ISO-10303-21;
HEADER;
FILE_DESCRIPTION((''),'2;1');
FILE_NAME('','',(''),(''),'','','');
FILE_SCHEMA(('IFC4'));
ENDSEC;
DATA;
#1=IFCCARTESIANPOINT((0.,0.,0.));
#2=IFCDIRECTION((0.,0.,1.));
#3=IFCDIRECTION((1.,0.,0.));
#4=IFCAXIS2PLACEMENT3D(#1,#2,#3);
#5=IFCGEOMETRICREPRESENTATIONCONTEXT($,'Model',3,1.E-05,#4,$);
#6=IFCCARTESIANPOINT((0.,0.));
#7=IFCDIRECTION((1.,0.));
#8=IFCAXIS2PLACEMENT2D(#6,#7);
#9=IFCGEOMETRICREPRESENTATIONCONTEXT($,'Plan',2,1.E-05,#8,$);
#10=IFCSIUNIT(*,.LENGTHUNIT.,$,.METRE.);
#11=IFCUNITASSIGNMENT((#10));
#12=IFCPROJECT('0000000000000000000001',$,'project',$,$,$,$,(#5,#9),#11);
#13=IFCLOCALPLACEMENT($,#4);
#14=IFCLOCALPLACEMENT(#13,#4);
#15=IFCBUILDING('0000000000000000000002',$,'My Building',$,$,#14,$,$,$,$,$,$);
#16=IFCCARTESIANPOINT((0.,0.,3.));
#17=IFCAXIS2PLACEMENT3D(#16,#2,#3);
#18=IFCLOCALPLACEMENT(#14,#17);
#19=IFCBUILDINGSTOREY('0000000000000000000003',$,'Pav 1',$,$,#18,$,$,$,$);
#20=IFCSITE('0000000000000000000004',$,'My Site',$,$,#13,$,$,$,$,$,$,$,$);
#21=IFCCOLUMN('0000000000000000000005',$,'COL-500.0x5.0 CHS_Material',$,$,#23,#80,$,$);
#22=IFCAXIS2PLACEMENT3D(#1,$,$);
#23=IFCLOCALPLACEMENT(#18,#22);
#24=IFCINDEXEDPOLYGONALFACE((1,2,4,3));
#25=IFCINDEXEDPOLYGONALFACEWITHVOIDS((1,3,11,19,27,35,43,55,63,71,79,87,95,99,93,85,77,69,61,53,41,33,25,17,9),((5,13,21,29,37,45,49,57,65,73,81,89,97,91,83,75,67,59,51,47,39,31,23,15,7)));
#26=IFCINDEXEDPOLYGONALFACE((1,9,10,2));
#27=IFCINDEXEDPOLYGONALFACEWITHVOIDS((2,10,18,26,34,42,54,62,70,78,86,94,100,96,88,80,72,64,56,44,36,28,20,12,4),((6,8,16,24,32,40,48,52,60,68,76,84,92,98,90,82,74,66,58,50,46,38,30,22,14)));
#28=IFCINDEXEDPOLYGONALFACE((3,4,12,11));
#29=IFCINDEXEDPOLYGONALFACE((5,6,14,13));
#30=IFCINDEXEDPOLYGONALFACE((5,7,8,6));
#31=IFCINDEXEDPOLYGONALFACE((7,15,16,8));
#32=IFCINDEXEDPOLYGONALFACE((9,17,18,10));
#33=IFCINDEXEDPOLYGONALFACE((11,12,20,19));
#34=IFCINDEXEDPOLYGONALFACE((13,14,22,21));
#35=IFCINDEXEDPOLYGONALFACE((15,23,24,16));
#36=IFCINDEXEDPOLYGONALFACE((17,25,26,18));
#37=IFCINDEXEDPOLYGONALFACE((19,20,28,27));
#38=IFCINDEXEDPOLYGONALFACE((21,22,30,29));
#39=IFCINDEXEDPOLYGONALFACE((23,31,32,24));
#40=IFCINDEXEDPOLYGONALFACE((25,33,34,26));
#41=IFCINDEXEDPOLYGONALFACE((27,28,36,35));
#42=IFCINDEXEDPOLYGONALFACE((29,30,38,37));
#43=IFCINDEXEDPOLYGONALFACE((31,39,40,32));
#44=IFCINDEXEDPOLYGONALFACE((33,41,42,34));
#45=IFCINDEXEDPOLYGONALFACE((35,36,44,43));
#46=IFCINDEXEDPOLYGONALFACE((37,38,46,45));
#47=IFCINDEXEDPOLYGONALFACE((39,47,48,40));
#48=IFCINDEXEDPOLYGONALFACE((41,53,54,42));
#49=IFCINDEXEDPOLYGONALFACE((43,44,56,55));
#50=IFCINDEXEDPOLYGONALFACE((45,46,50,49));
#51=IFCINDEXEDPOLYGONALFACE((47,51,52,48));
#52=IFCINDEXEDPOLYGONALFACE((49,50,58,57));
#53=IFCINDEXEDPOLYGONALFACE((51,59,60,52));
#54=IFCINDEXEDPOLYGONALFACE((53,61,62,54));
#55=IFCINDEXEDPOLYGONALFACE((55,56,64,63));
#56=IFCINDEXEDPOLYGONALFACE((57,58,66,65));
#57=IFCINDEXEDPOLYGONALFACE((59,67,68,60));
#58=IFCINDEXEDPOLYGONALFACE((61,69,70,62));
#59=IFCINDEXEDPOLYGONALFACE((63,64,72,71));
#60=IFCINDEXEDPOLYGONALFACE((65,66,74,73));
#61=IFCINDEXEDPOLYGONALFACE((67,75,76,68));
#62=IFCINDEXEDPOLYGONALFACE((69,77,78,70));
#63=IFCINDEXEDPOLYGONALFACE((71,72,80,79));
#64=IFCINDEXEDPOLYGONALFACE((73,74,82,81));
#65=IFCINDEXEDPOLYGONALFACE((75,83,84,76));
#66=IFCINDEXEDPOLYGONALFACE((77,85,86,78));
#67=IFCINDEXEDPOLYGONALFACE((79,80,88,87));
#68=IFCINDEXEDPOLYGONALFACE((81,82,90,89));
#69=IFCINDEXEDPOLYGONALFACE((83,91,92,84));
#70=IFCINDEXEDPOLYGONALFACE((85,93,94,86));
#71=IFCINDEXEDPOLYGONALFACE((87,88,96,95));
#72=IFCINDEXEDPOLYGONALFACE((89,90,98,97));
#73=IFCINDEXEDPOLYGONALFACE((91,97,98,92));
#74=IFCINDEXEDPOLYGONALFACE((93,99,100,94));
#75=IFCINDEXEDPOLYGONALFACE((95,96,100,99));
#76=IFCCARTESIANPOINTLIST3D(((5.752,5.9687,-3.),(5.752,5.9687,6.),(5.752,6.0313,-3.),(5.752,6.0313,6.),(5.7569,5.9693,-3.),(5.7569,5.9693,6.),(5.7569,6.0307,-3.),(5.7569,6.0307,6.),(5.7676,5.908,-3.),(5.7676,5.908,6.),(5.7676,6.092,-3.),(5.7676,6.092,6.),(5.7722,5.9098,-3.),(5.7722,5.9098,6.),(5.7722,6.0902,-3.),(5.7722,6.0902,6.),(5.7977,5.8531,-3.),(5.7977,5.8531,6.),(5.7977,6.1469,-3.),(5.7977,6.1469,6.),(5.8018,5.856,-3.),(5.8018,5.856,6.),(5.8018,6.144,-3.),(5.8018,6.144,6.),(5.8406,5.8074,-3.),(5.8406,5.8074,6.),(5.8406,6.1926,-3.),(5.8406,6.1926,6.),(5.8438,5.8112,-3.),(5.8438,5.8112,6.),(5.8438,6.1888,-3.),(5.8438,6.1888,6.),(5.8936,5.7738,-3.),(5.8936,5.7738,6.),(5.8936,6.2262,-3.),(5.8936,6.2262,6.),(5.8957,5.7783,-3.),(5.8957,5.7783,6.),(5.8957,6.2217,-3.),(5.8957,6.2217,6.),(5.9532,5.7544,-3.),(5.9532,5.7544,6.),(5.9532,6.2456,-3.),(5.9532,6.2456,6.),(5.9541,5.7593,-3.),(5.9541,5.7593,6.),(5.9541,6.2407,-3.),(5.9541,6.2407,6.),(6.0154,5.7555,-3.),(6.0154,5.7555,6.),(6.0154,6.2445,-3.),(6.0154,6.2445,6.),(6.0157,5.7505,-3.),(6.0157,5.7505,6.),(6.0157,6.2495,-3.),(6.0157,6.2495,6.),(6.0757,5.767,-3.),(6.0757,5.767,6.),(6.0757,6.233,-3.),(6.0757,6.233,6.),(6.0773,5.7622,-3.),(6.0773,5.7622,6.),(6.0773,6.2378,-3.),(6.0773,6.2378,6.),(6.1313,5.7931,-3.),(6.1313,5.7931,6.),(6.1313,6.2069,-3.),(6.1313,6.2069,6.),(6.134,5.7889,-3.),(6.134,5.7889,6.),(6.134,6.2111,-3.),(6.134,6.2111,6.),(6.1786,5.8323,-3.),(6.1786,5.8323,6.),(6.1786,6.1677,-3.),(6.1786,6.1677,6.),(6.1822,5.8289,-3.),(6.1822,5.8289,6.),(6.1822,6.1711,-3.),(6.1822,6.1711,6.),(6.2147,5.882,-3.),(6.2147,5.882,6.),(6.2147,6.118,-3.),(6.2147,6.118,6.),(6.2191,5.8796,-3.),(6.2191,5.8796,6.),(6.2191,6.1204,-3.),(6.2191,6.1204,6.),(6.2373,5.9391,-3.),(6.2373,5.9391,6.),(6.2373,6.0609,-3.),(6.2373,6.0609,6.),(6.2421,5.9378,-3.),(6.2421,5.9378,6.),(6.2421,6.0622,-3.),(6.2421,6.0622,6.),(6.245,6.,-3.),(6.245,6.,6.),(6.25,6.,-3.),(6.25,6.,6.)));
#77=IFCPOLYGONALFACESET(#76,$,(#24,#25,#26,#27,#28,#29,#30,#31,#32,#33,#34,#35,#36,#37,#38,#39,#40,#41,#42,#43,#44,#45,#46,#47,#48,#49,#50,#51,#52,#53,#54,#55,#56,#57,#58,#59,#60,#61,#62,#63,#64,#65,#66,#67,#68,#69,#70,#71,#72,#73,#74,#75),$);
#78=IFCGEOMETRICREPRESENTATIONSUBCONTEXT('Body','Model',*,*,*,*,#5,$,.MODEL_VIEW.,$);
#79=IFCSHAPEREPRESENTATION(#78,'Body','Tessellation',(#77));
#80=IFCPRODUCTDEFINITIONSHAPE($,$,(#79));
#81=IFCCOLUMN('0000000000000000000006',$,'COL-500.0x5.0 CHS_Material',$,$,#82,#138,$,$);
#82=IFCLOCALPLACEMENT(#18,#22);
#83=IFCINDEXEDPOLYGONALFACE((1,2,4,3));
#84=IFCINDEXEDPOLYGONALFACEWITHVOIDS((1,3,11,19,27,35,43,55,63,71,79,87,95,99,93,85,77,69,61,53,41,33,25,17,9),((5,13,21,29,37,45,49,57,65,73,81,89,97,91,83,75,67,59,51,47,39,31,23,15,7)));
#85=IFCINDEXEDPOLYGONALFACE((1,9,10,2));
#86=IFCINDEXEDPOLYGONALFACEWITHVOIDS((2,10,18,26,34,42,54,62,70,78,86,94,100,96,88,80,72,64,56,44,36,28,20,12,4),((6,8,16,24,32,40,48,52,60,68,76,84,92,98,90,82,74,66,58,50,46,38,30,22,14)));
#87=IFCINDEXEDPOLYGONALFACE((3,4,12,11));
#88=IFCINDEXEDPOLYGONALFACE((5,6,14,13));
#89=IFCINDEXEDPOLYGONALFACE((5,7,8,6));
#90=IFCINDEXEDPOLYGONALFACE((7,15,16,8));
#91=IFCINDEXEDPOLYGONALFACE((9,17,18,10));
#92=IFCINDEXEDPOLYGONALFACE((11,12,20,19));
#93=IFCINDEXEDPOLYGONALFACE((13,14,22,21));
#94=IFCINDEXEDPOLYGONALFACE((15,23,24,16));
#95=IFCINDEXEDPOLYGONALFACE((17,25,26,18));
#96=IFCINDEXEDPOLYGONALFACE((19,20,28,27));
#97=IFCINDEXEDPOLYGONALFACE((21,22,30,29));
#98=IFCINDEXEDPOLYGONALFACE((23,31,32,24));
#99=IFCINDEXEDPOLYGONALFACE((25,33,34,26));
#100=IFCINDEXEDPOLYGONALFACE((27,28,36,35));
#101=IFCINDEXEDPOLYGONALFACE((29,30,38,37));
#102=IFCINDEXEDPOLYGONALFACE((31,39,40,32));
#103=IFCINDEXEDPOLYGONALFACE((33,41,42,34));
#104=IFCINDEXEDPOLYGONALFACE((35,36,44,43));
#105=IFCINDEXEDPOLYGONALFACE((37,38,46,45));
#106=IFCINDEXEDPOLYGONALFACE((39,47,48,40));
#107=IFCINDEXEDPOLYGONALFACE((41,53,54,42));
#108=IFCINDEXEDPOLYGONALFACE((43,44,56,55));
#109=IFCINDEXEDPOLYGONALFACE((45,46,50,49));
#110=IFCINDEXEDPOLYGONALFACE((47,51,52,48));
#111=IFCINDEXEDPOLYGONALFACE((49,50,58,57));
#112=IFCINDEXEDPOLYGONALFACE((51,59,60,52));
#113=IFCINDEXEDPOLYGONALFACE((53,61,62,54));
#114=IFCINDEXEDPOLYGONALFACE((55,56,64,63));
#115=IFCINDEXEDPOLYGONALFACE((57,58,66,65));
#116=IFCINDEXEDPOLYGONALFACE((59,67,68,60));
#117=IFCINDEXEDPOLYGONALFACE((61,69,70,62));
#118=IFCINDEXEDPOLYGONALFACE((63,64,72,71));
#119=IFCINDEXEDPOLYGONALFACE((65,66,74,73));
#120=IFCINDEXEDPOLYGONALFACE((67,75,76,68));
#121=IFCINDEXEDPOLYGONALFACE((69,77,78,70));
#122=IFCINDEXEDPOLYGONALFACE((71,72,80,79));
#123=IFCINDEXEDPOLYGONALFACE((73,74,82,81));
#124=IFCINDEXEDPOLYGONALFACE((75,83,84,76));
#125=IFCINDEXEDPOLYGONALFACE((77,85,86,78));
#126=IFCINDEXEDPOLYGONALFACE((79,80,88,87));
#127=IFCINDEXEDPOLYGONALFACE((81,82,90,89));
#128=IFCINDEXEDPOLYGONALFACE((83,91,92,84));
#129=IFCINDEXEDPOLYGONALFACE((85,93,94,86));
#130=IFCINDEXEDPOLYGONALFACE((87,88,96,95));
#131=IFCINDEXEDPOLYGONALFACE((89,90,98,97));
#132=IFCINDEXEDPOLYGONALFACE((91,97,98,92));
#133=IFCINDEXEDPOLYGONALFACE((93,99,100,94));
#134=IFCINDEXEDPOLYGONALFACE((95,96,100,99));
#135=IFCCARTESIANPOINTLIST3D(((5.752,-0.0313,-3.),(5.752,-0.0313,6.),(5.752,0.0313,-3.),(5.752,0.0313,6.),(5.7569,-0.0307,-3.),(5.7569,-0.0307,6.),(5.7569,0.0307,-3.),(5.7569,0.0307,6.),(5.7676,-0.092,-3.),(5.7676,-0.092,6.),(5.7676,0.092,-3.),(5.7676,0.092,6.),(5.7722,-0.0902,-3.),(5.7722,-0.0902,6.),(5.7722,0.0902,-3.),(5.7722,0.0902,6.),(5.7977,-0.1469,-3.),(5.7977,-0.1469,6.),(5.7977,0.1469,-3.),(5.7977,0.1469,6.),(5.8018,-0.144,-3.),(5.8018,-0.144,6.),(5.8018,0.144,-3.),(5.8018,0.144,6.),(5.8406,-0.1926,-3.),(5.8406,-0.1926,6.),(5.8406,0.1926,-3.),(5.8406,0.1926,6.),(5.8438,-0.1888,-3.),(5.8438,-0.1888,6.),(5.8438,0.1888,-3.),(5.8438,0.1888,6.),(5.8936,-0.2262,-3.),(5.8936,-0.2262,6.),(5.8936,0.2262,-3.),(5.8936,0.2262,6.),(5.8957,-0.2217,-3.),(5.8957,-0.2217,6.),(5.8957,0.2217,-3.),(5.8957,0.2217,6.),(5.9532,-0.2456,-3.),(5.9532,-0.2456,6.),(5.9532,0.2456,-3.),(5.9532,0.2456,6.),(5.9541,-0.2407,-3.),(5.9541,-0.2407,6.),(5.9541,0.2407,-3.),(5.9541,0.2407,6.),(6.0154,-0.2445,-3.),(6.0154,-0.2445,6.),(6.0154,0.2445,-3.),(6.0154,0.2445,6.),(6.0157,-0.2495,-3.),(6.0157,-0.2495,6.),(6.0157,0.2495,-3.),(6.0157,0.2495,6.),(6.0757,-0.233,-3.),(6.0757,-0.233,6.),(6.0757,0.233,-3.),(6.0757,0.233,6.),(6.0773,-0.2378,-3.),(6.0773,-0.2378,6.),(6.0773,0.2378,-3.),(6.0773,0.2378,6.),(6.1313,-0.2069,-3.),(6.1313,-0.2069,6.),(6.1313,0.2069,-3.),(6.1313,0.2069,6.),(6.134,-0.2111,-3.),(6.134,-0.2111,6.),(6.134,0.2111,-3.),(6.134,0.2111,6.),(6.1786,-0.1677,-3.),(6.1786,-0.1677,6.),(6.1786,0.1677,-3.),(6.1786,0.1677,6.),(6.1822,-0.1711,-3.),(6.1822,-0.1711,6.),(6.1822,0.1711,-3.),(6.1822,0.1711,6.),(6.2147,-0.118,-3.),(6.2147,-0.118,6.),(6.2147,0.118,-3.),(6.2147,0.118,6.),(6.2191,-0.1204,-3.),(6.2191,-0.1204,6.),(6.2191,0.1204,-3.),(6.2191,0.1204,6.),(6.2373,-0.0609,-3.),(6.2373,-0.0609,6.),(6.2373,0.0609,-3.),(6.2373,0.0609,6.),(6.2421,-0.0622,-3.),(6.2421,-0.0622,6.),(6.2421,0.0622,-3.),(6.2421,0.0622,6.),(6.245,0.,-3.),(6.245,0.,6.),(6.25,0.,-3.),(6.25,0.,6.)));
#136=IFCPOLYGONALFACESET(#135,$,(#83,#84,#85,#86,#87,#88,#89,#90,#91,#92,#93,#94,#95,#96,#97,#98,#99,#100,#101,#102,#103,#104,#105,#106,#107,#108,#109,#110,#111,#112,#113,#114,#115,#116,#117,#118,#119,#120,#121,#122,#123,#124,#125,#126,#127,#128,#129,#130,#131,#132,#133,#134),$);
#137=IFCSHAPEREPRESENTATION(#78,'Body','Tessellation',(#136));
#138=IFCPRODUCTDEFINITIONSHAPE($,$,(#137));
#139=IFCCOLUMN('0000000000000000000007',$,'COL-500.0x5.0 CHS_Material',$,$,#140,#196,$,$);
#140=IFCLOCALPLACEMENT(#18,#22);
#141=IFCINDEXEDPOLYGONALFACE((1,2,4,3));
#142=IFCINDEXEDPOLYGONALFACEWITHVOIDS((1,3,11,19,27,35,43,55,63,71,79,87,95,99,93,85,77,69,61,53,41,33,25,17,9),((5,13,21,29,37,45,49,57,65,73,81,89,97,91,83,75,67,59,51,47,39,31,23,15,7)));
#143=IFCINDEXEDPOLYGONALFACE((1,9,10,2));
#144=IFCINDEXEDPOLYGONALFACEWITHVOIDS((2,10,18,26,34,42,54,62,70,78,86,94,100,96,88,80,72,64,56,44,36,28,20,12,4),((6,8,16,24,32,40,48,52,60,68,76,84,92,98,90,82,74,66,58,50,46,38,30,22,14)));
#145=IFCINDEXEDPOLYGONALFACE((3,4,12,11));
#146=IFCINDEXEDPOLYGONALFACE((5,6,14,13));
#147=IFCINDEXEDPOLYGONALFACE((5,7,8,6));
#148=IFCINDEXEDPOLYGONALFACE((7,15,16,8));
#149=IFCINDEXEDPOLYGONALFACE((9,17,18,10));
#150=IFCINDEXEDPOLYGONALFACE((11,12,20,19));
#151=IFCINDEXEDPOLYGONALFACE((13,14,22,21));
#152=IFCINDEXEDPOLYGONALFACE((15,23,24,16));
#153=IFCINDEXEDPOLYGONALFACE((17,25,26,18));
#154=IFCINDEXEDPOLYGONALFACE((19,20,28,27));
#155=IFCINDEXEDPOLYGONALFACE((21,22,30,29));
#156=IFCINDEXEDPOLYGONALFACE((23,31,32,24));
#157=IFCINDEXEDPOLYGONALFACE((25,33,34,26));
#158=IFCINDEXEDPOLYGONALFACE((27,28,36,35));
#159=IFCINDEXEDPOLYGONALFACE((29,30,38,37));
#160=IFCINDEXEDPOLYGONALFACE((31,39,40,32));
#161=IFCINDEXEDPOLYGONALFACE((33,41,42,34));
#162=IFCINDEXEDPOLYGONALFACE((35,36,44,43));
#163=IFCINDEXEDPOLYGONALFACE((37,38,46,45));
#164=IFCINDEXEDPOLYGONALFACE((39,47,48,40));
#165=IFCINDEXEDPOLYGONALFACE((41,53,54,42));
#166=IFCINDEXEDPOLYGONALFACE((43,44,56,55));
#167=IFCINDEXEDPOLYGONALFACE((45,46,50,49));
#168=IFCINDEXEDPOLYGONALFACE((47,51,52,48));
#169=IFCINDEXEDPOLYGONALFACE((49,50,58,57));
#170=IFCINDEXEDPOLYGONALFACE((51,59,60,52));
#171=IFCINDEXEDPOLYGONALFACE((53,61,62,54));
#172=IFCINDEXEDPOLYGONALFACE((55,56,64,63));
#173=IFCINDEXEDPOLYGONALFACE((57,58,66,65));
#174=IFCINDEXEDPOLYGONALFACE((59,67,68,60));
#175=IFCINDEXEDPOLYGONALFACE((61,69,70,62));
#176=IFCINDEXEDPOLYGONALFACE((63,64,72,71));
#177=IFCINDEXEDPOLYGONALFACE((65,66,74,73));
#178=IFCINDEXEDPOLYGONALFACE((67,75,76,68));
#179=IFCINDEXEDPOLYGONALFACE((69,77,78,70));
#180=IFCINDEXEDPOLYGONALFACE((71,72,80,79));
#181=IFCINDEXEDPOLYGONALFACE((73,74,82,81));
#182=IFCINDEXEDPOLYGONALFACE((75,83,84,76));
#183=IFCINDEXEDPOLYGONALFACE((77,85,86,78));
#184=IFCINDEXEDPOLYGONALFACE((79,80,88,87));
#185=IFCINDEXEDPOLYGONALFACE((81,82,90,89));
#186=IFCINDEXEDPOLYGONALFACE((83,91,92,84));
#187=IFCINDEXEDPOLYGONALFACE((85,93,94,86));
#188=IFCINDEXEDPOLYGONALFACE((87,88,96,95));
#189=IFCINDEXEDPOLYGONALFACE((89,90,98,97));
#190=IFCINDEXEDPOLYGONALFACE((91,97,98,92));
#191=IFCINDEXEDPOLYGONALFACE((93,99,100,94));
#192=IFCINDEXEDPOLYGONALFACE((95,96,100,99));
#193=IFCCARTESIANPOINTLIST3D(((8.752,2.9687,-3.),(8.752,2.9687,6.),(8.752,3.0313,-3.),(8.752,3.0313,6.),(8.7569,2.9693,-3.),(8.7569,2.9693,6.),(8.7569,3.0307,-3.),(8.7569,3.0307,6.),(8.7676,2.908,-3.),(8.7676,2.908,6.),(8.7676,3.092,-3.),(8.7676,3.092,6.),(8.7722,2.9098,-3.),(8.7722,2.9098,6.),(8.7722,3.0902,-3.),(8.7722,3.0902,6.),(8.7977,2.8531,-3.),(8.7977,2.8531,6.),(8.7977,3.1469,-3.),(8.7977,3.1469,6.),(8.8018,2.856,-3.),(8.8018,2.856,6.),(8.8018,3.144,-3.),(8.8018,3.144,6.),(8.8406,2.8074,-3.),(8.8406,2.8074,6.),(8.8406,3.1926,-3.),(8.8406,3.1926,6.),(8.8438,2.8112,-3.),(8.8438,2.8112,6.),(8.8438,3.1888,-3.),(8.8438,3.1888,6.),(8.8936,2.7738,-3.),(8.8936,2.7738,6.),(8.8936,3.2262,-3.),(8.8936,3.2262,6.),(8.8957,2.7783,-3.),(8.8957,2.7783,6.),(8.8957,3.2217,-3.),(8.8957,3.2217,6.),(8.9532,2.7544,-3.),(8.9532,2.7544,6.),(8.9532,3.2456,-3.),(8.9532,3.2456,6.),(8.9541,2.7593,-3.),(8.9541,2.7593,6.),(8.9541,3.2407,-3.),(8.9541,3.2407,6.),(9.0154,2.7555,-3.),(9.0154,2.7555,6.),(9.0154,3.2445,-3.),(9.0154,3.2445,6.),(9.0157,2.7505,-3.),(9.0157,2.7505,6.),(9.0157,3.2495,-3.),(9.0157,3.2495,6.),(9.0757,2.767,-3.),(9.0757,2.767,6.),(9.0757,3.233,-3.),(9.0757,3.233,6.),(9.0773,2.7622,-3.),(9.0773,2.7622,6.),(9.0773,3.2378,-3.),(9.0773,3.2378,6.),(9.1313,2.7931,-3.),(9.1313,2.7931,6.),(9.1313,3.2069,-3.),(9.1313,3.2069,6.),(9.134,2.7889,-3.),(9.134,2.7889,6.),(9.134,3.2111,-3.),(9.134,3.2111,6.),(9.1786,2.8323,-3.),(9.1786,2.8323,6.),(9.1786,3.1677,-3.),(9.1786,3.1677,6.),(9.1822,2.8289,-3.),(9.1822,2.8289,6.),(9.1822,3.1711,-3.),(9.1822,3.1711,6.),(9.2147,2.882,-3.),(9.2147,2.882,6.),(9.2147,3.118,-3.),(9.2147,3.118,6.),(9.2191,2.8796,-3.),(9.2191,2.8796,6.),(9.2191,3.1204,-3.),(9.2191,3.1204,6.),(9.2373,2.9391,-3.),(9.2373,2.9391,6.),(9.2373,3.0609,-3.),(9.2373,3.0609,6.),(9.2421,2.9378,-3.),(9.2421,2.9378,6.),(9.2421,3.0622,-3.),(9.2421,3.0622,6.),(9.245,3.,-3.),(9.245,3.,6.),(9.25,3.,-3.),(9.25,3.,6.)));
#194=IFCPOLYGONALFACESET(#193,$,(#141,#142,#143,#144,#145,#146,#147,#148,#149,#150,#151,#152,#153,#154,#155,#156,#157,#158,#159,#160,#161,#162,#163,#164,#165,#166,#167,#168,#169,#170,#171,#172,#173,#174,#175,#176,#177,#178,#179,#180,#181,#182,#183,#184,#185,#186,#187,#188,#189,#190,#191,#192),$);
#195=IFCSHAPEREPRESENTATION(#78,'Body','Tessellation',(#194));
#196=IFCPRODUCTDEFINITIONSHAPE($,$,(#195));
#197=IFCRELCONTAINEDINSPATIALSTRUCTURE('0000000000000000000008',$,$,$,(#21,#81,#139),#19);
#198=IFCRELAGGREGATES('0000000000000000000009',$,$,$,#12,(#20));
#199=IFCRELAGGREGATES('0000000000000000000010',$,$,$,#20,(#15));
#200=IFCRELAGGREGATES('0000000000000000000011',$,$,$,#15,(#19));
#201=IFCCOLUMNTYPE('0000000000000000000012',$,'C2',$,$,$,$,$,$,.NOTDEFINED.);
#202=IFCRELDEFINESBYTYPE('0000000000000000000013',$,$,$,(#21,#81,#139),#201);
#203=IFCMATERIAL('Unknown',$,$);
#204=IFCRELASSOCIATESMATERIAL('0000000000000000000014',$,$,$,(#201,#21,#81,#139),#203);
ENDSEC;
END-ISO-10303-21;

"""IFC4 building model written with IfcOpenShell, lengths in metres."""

from ifc_helpers import new_model, si_unit, frame, origin, origin_with_axes, origin_2d_with_axis, place, context, subcontext, project, spatial, hollow_circle, extrude, material, material_profile, profile_set, profile_usage, type_object, element, save


model = new_model("IFC4")

# Units and contexts
model_context = context("Model", 3, precision=1e-05, world=origin_with_axes())
plan_context = context("Plan", 2, precision=1e-05, world=origin_2d_with_axis())
body_context = subcontext(model_context, "Body", "Model", "MODEL_VIEW")
ifc_project = project(units=[si_unit("LENGTHUNIT", "METRE")], contexts=[model_context, plan_context])

# Site, building, storey
site_placement = place(None, origin_with_axes())
site = spatial("IfcSite", under=ifc_project, at=site_placement, Name="My Site")
building_placement = place(site_placement, origin_with_axes())
building = spatial("IfcBuilding", under=site, at=building_placement, Name="My Building")
storey_placement = place(building_placement, frame((0.0, 0.0, 3.0), z_axis=(0.0, 0.0, 1.0), x_axis=(1.0, 0.0, 0.0)))
storey = spatial("IfcBuildingStorey", under=building, at=storey_placement, Name="Pav 1")

# Columns
ifc_material = material(Name="Unknown")
ifc_material_profile = material_profile(ifc_material, hollow_circle(Radius=0.25, WallThickness=0.005))
ifc_profile_set = profile_set([ifc_material_profile])
column_type = type_object("IfcColumnType", Name="C2", PredefinedType="NOTDEFINED", material=ifc_profile_set)
ifc_profile_usage_1 = profile_usage(ifc_profile_set, cardinal=5)
column_1_placement = place(storey_placement, frame((6.0, 6.0, -3.0), z_axis=(0.0, 0.0, 1.0), x_axis=(1.0, 0.0, 0.0)))
element("IfcColumn", 1, at=column_1_placement, inside=storey, type_object=column_type, material=ifc_profile_usage_1, Name="COL-500.0x5.0 CHS_Material", context=body_context, shape_type="SweptSolid", body=[
    extrude(hollow_circle(Radius=0.25, WallThickness=0.005), origin(), (0.0, 0.0, 1.0), 9.0),
])
ifc_profile_usage_2 = profile_usage(ifc_profile_set, cardinal=5)
column_2_placement = place(storey_placement, frame((6.0, 0.0, -3.0), z_axis=(0.0, 0.0, 1.0), x_axis=(1.0, 0.0, 0.0)))
element("IfcColumn", 2, at=column_2_placement, inside=storey, type_object=column_type, material=ifc_profile_usage_2, Name="COL-500.0x5.0 CHS_Material", context=body_context, shape_type="SweptSolid", body=[
    extrude(hollow_circle(Radius=0.25, WallThickness=0.005), origin(), (0.0, 0.0, 1.0), 9.0),
])
ifc_profile_usage_3 = profile_usage(ifc_profile_set, cardinal=5)
column_3_placement = place(storey_placement, frame((9.0, 3.0, -3.0), z_axis=(0.0, 0.0, 1.0), x_axis=(1.0, 0.0, 0.0)))
element("IfcColumn", 3, at=column_3_placement, inside=storey, type_object=column_type, material=ifc_profile_usage_3, Name="COL-500.0x5.0 CHS_Material", context=body_context, shape_type="SweptSolid", body=[
    extrude(hollow_circle(Radius=0.25, WallThickness=0.005), origin(), (0.0, 0.0, 1.0), 9.0),
])

save(model, "model.ifc")
